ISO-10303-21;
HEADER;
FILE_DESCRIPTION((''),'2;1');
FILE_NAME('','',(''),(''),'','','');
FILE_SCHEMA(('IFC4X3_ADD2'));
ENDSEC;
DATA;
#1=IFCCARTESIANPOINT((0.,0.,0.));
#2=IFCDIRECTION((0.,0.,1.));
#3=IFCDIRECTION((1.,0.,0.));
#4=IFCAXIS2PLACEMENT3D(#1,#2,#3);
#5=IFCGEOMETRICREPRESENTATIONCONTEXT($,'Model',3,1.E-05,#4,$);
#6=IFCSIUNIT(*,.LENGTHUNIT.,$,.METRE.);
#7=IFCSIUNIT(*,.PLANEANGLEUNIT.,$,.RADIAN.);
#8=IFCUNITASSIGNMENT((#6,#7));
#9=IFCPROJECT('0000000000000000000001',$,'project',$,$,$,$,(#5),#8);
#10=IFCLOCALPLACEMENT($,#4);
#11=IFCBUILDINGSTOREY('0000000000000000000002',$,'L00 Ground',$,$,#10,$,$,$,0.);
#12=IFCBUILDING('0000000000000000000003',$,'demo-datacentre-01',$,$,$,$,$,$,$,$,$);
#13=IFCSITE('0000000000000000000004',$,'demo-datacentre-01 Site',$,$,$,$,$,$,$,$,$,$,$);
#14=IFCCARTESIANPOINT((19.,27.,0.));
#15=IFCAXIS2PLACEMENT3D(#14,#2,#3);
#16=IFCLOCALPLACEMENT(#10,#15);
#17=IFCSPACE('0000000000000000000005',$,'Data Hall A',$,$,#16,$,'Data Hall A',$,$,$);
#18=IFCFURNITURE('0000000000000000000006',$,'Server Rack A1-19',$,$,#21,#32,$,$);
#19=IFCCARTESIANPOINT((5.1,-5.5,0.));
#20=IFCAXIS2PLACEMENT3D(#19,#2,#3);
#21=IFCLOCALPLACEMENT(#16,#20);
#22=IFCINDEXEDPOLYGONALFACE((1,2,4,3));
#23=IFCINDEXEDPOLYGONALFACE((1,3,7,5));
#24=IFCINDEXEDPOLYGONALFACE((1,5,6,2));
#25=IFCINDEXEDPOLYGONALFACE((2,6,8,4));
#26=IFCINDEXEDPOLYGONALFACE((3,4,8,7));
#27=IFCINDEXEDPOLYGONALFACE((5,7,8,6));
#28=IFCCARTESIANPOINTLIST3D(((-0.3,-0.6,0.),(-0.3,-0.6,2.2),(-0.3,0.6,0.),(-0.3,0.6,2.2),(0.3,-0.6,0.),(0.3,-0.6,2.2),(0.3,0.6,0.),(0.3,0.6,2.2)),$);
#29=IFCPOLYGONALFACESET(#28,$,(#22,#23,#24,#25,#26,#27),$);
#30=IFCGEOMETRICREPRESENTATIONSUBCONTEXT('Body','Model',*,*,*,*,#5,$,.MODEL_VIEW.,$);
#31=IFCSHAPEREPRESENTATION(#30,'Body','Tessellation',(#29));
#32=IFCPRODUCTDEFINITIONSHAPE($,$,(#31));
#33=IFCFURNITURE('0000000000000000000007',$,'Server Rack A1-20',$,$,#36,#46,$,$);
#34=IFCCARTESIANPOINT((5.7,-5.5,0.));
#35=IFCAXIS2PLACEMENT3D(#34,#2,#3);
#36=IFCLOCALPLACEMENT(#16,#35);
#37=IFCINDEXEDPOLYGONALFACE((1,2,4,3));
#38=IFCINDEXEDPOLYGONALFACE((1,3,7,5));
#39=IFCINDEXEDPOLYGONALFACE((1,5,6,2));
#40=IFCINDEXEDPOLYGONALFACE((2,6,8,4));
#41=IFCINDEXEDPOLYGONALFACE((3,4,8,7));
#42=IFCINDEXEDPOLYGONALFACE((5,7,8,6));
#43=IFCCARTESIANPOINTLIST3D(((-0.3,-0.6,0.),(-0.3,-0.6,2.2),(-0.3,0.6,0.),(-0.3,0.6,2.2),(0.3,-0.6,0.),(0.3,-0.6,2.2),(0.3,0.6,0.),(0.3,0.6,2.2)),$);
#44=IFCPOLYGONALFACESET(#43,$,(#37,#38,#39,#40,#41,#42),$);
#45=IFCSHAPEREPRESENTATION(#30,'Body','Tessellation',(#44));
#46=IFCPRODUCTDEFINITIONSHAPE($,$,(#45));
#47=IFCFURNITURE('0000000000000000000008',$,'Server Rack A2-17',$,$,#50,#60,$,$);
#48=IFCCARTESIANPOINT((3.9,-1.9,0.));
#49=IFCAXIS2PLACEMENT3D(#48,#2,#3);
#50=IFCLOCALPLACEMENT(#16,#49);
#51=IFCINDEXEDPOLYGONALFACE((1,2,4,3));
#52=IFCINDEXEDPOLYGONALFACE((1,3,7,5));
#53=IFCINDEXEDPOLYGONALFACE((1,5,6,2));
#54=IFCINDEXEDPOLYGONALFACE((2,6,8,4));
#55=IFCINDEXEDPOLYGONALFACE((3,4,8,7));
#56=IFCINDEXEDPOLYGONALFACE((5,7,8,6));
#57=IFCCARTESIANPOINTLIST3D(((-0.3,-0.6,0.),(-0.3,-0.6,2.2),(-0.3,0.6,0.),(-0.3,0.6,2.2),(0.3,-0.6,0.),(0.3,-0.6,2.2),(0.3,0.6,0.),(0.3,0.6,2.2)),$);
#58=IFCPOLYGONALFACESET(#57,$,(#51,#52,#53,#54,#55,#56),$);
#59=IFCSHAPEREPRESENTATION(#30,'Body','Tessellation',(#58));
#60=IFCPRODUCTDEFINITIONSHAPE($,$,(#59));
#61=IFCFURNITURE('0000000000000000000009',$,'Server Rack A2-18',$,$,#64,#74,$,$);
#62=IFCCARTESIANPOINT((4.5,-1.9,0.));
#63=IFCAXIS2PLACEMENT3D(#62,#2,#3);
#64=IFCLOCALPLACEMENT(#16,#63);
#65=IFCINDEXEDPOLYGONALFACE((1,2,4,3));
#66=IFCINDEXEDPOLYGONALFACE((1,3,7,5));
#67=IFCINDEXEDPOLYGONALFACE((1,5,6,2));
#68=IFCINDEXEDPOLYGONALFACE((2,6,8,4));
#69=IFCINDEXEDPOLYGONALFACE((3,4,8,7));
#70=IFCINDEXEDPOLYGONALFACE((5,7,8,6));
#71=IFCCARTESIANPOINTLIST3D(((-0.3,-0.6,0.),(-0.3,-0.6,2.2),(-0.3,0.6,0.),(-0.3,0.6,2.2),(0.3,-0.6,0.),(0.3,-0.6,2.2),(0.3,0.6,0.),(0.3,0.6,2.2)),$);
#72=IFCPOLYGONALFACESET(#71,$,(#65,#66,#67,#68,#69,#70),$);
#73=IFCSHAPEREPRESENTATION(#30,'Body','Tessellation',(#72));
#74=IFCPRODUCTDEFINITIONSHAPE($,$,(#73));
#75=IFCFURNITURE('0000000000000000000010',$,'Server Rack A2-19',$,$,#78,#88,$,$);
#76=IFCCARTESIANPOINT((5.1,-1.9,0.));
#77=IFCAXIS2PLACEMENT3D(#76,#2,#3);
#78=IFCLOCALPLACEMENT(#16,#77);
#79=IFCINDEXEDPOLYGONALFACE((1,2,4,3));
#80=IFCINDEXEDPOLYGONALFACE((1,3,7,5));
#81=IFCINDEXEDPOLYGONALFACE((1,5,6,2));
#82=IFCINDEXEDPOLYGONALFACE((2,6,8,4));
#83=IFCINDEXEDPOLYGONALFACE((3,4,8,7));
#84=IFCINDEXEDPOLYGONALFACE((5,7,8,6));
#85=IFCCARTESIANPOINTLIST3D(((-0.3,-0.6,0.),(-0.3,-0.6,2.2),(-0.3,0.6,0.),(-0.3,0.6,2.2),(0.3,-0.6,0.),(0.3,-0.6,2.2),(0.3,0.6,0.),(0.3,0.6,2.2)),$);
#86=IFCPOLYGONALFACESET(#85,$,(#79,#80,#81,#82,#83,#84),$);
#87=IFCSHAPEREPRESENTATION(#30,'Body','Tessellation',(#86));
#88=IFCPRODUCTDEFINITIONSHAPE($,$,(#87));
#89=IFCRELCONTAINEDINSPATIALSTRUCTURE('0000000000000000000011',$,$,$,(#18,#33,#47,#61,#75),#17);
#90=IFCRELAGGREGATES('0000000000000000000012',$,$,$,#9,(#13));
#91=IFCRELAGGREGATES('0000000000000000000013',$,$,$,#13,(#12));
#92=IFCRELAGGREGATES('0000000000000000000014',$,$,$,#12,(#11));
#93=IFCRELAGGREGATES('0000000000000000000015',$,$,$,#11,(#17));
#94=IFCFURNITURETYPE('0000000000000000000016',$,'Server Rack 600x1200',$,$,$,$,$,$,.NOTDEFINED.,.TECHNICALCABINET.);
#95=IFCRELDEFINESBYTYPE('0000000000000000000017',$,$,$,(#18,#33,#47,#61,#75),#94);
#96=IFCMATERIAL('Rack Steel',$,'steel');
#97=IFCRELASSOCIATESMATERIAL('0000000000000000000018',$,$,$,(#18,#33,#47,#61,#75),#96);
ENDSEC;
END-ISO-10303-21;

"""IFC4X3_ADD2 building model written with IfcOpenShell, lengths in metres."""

from ifc_helpers import new_model, si_unit, frame, origin_with_axes, place, context, subcontext, project, spatial, rectangle, extrude, material, type_object, element, save


model = new_model("IFC4X3_ADD2")

# Units and contexts
model_context = context("Model", 3, precision=1e-05, world=origin_with_axes())
body_context = subcontext(model_context, "Body", "Model", "MODEL_VIEW")
ifc_project = project(units=[si_unit("LENGTHUNIT", "METRE"), si_unit("PLANEANGLEUNIT", "RADIAN")], contexts=[model_context])

# Site, building, storey
site = spatial("IfcSite", under=ifc_project, Name="demo-datacentre-01 Site")
building = spatial("IfcBuilding", under=site, Name="demo-datacentre-01")
storey_placement = place(None, origin_with_axes())
storey = spatial("IfcBuildingStorey", under=building, at=storey_placement, Name="L00 Ground", Elevation=0.0)

# Shared definitions
space_placement = place(storey_placement, frame((19.0, 27.0, 0.0), z_axis=(0.0, 0.0, 1.0), x_axis=(1.0, 0.0, 0.0)))
space = spatial("IfcSpace", under=storey, at=space_placement, Name="Data Hall A", LongName="Data Hall A")

# Furniture
ifc_material_1 = material(Name="Rack Steel", Category="steel")
furniture_type = type_object("IfcFurnitureType", Name="Server Rack 600x1200", AssemblyPlace="NOTDEFINED", PredefinedType="TECHNICALCABINET")
for number, where, z_axis, x_axis, name in (
    (1, (5.1, -5.5, 0.0), (0.0, 0.0, 1.0), (1.0, 0.0, 0.0), "Server Rack A1-19"),
    (2, (5.7, -5.5, 0.0), (0.0, 0.0, 1.0), (1.0, 0.0, 0.0), "Server Rack A1-20"),
    (3, (3.9, -1.9, 0.0), (0.0, 0.0, 1.0), (1.0, 0.0, 0.0), "Server Rack A2-17"),
    (4, (4.5, -1.9, 0.0), (0.0, 0.0, 1.0), (1.0, 0.0, 0.0), "Server Rack A2-18"),
    (5, (5.1, -1.9, 0.0), (0.0, 0.0, 1.0), (1.0, 0.0, 0.0), "Server Rack A2-19"),
):
    element("IfcFurniture", number, at=place(space_placement, frame(where, z_axis=z_axis, x_axis=x_axis)), inside=space, type_object=furniture_type, material=ifc_material_1, Name=name, context=body_context, shape_type="SweptSolid", body=[
        extrude(rectangle(XDim=0.6, YDim=1.2), origin_with_axes(), (0.0, 0.0, 1.0), 2.2),
    ])

save(model, "model.ifc")
